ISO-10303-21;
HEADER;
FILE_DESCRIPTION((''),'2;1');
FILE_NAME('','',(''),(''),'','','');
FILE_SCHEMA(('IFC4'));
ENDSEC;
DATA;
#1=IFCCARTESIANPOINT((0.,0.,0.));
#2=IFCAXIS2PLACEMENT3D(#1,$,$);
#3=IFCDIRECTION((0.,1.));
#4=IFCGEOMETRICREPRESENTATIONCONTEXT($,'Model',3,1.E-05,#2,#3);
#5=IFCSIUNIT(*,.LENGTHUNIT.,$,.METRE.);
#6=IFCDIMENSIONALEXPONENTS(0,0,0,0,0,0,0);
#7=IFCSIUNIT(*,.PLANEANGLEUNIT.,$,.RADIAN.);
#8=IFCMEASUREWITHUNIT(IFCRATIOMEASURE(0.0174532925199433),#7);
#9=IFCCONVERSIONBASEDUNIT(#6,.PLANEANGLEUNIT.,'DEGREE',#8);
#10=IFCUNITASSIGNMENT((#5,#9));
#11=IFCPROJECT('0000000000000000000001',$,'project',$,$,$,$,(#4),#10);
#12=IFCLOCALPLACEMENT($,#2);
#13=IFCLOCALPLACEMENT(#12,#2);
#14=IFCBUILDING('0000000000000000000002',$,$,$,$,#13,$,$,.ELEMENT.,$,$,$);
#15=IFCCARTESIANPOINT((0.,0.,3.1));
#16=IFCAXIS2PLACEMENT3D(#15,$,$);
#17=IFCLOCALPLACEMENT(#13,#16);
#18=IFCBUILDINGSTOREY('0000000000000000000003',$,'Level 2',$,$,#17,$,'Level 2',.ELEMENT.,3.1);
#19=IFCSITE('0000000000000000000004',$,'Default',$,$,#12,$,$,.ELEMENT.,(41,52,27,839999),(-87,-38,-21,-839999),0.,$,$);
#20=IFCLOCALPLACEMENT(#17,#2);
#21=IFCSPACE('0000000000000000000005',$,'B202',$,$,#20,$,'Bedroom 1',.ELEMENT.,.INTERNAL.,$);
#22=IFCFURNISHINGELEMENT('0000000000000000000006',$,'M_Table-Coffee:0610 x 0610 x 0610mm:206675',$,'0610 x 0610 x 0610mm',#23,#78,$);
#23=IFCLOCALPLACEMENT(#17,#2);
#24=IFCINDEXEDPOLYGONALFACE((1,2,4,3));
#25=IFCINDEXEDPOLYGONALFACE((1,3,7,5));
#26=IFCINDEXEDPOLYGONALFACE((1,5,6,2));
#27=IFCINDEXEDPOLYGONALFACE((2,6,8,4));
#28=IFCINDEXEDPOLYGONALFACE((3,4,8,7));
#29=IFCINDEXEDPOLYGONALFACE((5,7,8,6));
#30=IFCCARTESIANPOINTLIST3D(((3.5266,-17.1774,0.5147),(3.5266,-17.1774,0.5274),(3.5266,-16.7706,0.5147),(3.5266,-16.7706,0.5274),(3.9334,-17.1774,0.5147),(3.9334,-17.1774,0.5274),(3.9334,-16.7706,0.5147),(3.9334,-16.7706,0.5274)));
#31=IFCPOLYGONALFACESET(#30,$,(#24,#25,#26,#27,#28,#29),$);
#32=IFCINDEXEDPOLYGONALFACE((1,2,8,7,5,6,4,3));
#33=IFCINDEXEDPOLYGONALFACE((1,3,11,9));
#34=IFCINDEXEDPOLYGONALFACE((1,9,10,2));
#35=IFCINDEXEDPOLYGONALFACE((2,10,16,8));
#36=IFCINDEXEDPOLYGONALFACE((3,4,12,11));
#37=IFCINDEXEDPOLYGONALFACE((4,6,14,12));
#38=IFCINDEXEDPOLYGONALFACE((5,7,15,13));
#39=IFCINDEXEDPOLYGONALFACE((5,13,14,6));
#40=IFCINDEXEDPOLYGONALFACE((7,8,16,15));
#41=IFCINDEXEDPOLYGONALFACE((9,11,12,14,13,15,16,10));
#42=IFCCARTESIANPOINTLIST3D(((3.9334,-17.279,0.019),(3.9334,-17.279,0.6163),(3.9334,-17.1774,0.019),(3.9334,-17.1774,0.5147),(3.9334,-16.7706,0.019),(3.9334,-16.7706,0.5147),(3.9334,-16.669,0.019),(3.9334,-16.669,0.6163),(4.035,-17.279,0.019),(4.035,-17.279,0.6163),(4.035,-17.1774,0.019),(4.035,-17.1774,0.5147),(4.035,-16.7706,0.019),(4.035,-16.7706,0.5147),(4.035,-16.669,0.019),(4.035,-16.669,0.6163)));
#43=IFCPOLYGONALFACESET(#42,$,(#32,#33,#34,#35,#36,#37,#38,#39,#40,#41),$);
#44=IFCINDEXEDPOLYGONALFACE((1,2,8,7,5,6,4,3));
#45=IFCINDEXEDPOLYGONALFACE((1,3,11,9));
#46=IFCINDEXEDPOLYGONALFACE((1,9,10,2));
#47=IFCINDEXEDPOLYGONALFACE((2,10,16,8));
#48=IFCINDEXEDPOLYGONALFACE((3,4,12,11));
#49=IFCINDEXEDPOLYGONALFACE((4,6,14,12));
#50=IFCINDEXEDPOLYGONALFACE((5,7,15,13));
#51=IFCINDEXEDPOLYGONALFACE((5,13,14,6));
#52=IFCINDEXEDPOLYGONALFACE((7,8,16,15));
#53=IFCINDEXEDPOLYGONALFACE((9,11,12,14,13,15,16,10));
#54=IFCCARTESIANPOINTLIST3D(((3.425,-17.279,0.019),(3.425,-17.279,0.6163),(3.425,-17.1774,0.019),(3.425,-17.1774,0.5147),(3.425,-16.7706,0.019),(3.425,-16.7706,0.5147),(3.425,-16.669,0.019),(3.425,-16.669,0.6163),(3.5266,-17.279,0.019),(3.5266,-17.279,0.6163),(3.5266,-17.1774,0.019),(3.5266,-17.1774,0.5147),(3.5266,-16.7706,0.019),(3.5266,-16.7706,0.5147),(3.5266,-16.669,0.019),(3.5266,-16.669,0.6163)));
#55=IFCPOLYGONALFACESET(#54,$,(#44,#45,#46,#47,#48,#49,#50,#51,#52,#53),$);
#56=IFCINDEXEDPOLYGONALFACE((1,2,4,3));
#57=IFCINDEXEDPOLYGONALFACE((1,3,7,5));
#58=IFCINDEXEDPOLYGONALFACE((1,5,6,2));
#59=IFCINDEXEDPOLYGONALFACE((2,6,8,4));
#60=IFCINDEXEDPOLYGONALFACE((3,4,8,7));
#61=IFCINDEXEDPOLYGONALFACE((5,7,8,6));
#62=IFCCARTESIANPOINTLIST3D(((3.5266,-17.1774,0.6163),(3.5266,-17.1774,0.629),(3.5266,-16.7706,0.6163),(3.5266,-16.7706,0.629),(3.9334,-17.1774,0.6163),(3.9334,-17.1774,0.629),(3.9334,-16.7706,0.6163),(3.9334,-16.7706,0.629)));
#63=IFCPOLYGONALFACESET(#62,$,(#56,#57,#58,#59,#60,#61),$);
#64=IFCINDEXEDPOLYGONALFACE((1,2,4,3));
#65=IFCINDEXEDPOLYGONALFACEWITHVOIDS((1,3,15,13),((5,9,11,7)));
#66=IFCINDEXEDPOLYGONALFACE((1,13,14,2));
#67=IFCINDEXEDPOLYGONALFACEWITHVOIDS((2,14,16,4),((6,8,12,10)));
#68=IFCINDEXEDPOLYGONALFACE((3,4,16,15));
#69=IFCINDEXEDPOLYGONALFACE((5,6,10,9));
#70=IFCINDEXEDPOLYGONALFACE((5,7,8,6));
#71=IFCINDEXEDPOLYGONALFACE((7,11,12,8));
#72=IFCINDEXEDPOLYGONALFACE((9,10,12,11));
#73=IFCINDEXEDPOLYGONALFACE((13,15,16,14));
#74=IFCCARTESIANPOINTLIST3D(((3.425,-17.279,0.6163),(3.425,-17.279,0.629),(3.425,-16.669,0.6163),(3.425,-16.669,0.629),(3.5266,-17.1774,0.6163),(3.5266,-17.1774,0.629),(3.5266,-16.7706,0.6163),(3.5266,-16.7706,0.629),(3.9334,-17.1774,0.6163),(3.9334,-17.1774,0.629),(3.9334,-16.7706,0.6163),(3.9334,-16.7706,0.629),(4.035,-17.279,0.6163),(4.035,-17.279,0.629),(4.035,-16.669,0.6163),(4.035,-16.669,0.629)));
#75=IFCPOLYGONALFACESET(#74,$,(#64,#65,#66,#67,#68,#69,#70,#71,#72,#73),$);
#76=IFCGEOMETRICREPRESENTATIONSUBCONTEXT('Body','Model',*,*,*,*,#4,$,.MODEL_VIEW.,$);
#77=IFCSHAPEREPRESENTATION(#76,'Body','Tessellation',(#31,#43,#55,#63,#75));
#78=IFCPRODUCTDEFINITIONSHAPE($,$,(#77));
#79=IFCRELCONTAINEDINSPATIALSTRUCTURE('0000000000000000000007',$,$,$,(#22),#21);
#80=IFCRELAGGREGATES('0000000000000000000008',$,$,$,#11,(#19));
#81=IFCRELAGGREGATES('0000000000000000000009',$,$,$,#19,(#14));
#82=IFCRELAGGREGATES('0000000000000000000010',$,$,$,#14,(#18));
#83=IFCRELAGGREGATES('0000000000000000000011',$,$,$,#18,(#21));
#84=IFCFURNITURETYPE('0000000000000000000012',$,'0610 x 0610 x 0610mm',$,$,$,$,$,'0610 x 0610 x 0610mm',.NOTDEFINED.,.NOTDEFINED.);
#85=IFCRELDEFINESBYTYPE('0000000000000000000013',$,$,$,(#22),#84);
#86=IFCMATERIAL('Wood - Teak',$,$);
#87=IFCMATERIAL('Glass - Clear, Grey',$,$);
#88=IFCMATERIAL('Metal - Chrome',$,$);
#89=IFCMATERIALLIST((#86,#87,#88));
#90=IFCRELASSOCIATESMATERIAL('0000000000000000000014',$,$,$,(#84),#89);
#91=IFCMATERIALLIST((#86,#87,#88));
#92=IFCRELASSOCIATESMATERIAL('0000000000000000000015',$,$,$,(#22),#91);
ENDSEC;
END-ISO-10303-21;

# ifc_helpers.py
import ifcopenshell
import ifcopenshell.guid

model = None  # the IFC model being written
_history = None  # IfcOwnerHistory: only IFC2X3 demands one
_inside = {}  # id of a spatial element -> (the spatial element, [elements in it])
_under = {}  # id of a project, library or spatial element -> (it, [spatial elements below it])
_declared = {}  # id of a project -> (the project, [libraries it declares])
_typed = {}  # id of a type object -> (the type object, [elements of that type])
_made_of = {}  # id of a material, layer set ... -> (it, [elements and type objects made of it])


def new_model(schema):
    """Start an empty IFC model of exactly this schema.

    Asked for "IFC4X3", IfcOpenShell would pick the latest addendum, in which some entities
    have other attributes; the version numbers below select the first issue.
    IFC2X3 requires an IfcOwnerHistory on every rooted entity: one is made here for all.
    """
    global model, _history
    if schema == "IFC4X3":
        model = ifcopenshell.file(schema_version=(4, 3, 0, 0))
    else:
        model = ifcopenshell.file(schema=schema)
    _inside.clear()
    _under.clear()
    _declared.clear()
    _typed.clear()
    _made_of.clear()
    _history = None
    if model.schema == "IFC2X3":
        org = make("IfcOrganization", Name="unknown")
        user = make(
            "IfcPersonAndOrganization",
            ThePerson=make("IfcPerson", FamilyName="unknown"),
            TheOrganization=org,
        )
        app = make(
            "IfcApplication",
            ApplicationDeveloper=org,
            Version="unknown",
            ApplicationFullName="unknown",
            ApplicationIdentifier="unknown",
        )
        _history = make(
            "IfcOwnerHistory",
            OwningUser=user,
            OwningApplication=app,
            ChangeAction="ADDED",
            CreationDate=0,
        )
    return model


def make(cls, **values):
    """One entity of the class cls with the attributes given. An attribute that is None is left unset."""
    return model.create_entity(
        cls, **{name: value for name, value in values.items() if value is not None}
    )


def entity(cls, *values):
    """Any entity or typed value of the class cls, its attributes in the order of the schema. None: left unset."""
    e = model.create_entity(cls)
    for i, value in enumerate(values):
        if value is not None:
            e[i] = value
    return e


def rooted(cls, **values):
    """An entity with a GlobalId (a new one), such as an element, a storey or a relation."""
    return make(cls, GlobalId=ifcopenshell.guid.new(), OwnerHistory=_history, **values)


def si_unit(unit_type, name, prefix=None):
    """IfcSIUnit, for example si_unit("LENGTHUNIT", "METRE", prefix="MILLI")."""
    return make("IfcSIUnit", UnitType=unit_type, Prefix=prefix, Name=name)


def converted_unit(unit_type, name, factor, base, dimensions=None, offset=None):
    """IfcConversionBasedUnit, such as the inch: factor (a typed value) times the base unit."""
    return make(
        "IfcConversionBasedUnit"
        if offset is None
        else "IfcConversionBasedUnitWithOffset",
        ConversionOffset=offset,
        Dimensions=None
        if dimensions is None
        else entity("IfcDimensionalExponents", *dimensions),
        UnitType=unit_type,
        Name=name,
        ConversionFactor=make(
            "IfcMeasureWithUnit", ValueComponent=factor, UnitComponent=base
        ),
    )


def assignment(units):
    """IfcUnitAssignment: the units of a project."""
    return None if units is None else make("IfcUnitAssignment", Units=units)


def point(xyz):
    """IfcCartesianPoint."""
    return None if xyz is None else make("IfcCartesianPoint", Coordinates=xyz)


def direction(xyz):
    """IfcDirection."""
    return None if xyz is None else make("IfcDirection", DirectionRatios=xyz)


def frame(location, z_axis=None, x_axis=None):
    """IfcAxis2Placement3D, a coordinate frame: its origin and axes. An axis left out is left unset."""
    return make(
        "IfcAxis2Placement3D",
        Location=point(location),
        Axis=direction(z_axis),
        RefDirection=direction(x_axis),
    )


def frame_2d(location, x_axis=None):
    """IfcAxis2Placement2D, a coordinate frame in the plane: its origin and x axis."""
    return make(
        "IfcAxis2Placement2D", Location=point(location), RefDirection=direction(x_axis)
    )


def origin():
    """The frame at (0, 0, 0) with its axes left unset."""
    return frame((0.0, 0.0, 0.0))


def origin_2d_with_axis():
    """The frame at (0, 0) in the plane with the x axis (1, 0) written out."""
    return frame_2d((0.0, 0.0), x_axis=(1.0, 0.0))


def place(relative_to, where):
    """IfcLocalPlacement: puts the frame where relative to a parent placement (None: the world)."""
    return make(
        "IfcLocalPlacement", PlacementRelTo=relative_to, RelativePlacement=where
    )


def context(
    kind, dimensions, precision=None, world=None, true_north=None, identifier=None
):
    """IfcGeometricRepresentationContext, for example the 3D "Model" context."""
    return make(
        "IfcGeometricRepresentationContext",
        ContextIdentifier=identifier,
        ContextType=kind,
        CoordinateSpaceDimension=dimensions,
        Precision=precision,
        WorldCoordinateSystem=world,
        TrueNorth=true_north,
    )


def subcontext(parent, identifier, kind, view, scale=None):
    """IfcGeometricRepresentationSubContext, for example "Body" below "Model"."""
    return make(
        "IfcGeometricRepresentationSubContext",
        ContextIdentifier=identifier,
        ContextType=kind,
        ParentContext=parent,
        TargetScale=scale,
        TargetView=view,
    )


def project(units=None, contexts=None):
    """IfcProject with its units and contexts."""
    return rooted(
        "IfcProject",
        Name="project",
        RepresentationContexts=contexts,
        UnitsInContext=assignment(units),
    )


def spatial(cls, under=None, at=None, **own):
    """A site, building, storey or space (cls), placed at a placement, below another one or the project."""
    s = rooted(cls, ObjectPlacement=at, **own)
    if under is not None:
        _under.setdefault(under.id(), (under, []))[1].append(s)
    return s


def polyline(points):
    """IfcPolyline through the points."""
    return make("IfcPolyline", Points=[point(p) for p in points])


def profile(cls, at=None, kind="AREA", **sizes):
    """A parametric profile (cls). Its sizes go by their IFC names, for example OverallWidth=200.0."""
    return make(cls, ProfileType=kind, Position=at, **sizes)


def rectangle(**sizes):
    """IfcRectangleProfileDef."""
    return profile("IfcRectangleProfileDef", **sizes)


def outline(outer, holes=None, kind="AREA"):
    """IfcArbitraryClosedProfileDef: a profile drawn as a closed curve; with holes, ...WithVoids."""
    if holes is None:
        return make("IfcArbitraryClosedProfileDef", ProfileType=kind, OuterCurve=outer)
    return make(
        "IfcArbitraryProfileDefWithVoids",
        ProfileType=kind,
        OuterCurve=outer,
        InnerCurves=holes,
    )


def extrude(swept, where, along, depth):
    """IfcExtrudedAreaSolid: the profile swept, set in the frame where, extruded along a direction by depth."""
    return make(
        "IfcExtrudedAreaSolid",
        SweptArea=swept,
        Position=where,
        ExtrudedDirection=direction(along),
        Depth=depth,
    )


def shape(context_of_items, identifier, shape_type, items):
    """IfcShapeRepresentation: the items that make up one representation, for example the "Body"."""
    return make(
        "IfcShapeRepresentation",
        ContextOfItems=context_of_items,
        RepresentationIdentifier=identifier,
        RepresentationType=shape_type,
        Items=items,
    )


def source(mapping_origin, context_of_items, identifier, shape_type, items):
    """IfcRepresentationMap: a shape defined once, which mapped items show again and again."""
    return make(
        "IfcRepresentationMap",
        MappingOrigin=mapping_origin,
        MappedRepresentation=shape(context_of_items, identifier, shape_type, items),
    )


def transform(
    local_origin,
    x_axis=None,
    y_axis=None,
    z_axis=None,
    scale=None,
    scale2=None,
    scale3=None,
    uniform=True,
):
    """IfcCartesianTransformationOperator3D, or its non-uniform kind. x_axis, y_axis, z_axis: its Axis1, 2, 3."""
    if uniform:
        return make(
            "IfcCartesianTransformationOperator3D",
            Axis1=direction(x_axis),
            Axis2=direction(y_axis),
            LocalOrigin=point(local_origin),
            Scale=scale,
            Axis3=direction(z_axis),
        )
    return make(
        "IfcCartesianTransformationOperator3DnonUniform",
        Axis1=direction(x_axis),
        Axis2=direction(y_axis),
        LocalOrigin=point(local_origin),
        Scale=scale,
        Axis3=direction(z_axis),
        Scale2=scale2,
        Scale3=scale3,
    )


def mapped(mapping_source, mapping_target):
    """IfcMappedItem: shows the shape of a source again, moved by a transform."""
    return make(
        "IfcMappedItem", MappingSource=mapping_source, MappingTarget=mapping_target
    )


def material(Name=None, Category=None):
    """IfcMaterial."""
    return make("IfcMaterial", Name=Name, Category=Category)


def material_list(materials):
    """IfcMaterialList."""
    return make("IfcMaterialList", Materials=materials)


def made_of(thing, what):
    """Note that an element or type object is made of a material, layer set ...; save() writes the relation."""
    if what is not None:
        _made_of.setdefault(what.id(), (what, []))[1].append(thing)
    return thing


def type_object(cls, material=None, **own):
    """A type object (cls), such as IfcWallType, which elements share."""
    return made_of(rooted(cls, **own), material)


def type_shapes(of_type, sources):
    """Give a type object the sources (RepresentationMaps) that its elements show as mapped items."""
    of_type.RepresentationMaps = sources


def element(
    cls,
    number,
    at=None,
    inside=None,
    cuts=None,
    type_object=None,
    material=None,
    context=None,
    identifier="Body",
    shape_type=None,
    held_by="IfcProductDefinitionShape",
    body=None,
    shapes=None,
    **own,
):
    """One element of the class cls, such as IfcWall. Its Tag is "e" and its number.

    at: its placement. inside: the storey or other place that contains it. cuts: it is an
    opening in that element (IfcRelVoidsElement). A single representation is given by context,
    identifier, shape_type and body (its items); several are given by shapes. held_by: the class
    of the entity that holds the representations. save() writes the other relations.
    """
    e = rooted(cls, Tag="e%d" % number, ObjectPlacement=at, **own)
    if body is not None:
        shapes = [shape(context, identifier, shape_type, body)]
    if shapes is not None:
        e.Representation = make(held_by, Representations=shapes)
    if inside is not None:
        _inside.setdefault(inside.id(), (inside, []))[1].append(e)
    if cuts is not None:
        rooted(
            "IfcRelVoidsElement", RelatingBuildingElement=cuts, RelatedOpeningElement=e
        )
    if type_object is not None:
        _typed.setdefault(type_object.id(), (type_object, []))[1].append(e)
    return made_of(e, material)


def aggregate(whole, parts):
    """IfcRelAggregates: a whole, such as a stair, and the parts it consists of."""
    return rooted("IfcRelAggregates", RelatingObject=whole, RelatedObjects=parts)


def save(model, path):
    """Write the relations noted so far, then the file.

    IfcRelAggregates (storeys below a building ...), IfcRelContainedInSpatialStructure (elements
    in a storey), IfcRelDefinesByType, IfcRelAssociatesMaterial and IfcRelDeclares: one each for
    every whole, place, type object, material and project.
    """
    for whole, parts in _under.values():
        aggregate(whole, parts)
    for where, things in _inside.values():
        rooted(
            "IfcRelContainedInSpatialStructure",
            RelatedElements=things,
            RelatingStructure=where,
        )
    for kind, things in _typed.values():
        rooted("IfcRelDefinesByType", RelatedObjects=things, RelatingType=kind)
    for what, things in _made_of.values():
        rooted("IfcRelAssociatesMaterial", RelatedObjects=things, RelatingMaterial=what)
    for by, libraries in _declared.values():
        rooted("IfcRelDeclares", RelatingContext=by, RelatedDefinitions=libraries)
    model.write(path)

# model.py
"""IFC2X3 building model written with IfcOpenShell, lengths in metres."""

from ifc_helpers import new_model, entity, si_unit, converted_unit, direction, frame, origin, origin_2d_with_axis, place, context, subcontext, project, spatial, polyline, rectangle, outline, extrude, source, transform, mapped, material, material_list, type_object, type_shapes, element, save


model = new_model("IFC2X3")

# Units and contexts
model_context = context("Model", 3, precision=1e-05, world=origin(), true_north=direction((0.0, 1.0)))
body_context = subcontext(model_context, "Body", "Model", "MODEL_VIEW")
ifc_project = project(units=[si_unit("LENGTHUNIT", "METRE"), converted_unit("PLANEANGLEUNIT", "DEGREE", entity("IfcRatioMeasure", 0.0174532925199433), si_unit("PLANEANGLEUNIT", "RADIAN"), dimensions=[0, 0, 0, 0, 0, 0, 0])], contexts=[model_context])

# Site, building, storey
site_placement = place(None, origin())
site = spatial("IfcSite", under=ifc_project, at=site_placement, Name="Default", CompositionType="ELEMENT", RefLatitude=(41, 52, 27, 839999), RefLongitude=(-87, -38, -21, -839999), RefElevation=0.0)
building_placement = place(site_placement, origin())
building = spatial("IfcBuilding", under=site, at=building_placement, CompositionType="ELEMENT")
storey_placement = place(building_placement, frame((0.0, 0.0, 3.1)))
storey = spatial("IfcBuildingStorey", under=building, at=storey_placement, Name="Level 2", LongName="Level 2", CompositionType="ELEMENT", Elevation=3.1)

# Shared definitions
space_placement = place(storey_placement, origin())
space = spatial("IfcSpace", under=storey, at=space_placement, Name="B202", LongName="Bedroom 1", CompositionType="ELEMENT", InteriorOrExteriorSpace="INTERNAL")

# Furnishing element
ifc_material_1 = material(Name="Wood - Teak")
ifc_material_2 = material(Name="Glass - Clear, Grey")
ifc_material_3 = material(Name="Metal - Chrome")
ifc_material_list_1 = material_list([ifc_material_1, ifc_material_2, ifc_material_3])
ifc_material_list_2 = material_list([ifc_material_1, ifc_material_2, ifc_material_3])
furniture_type_1 = type_object("IfcFurnitureType", Name="0610 x 0610 x 0610mm", ElementType="0610 x 0610 x 0610mm", material=ifc_material_list_2)
shared_shape_1 = source(origin(), body_context, "Body", "SweptSolid", [
    extrude(rectangle(XDim=0.4068, YDim=0.4068, at=origin_2d_with_axis()), frame((0.0183, 0.0952, 0.4957), z_axis=(0.0, 0.0, 1.0), x_axis=(-1.0, 0.0, 0.0)), (0.0, 0.0, 1.0), 0.0127),
    extrude(outline(polyline([(-0.2732, -0.305), (0.324, -0.305), (0.324, 0.305), (-0.2732, 0.305), (-0.2732, 0.2034), (0.2225, 0.2034), (0.2225, -0.2034), (-0.2732, -0.2034), (-0.2732, -0.305)])), frame((0.2217, 0.0952, 0.2732), z_axis=(1.0, 0.0, 0.0), x_axis=(0.0, 0.0, 1.0)), (0.0, 0.0, 1.0), 0.1016),
    extrude(outline(polyline([(-0.305, -0.3241), (0.305, -0.3241), (0.305, 0.2733), (0.2034, 0.2733), (0.2034, -0.2224), (-0.2034, -0.2224), (-0.2034, 0.2733), (-0.305, 0.2733), (-0.305, -0.3241)])), frame((-0.2867, 0.0952, 0.2733), z_axis=(1.0, 0.0, 0.0), x_axis=(0.0, -1.0, 0.0)), (0.0, 0.0, 1.0), 0.1016),
    extrude(rectangle(XDim=0.4068, YDim=0.4068, at=origin_2d_with_axis()), frame((0.0183, 0.0952, 0.5973), z_axis=(0.0, 0.0, 1.0), x_axis=(-1.0, 0.0, 0.0)), (0.0, 0.0, 1.0), 0.0127),
    extrude(outline(polyline([(-0.305, -0.305), (0.305, -0.305), (0.305, 0.305), (-0.305, 0.305), (-0.305, -0.305)]), holes=[polyline([(-0.2034, -0.2034), (-0.2034, 0.2034), (0.2034, 0.2034), (0.2034, -0.2034), (-0.2034, -0.2034)])]), frame((0.0183, 0.0952, 0.5973), z_axis=(0.0, 0.0, 1.0), x_axis=(-1.0, 0.0, 0.0)), (0.0, 0.0, 1.0), 0.0127),
])
type_shapes(furniture_type_1, [shared_shape_1])
furnishing_1_placement = place(space_placement, frame((3.7117, -17.0692, 0.019)))
element("IfcFurnishingElement", 1, at=furnishing_1_placement, inside=space, type_object=furniture_type_1, material=ifc_material_list_1, Name="M_Table-Coffee:0610 x 0610 x 0610mm:206675", ObjectType="0610 x 0610 x 0610mm", context=body_context, shape_type="MappedRepresentation", body=[
    mapped(shared_shape_1, transform((0.0, 0.0, 0.0), scale=1.0)),
])

save(model, "model.ifc")
